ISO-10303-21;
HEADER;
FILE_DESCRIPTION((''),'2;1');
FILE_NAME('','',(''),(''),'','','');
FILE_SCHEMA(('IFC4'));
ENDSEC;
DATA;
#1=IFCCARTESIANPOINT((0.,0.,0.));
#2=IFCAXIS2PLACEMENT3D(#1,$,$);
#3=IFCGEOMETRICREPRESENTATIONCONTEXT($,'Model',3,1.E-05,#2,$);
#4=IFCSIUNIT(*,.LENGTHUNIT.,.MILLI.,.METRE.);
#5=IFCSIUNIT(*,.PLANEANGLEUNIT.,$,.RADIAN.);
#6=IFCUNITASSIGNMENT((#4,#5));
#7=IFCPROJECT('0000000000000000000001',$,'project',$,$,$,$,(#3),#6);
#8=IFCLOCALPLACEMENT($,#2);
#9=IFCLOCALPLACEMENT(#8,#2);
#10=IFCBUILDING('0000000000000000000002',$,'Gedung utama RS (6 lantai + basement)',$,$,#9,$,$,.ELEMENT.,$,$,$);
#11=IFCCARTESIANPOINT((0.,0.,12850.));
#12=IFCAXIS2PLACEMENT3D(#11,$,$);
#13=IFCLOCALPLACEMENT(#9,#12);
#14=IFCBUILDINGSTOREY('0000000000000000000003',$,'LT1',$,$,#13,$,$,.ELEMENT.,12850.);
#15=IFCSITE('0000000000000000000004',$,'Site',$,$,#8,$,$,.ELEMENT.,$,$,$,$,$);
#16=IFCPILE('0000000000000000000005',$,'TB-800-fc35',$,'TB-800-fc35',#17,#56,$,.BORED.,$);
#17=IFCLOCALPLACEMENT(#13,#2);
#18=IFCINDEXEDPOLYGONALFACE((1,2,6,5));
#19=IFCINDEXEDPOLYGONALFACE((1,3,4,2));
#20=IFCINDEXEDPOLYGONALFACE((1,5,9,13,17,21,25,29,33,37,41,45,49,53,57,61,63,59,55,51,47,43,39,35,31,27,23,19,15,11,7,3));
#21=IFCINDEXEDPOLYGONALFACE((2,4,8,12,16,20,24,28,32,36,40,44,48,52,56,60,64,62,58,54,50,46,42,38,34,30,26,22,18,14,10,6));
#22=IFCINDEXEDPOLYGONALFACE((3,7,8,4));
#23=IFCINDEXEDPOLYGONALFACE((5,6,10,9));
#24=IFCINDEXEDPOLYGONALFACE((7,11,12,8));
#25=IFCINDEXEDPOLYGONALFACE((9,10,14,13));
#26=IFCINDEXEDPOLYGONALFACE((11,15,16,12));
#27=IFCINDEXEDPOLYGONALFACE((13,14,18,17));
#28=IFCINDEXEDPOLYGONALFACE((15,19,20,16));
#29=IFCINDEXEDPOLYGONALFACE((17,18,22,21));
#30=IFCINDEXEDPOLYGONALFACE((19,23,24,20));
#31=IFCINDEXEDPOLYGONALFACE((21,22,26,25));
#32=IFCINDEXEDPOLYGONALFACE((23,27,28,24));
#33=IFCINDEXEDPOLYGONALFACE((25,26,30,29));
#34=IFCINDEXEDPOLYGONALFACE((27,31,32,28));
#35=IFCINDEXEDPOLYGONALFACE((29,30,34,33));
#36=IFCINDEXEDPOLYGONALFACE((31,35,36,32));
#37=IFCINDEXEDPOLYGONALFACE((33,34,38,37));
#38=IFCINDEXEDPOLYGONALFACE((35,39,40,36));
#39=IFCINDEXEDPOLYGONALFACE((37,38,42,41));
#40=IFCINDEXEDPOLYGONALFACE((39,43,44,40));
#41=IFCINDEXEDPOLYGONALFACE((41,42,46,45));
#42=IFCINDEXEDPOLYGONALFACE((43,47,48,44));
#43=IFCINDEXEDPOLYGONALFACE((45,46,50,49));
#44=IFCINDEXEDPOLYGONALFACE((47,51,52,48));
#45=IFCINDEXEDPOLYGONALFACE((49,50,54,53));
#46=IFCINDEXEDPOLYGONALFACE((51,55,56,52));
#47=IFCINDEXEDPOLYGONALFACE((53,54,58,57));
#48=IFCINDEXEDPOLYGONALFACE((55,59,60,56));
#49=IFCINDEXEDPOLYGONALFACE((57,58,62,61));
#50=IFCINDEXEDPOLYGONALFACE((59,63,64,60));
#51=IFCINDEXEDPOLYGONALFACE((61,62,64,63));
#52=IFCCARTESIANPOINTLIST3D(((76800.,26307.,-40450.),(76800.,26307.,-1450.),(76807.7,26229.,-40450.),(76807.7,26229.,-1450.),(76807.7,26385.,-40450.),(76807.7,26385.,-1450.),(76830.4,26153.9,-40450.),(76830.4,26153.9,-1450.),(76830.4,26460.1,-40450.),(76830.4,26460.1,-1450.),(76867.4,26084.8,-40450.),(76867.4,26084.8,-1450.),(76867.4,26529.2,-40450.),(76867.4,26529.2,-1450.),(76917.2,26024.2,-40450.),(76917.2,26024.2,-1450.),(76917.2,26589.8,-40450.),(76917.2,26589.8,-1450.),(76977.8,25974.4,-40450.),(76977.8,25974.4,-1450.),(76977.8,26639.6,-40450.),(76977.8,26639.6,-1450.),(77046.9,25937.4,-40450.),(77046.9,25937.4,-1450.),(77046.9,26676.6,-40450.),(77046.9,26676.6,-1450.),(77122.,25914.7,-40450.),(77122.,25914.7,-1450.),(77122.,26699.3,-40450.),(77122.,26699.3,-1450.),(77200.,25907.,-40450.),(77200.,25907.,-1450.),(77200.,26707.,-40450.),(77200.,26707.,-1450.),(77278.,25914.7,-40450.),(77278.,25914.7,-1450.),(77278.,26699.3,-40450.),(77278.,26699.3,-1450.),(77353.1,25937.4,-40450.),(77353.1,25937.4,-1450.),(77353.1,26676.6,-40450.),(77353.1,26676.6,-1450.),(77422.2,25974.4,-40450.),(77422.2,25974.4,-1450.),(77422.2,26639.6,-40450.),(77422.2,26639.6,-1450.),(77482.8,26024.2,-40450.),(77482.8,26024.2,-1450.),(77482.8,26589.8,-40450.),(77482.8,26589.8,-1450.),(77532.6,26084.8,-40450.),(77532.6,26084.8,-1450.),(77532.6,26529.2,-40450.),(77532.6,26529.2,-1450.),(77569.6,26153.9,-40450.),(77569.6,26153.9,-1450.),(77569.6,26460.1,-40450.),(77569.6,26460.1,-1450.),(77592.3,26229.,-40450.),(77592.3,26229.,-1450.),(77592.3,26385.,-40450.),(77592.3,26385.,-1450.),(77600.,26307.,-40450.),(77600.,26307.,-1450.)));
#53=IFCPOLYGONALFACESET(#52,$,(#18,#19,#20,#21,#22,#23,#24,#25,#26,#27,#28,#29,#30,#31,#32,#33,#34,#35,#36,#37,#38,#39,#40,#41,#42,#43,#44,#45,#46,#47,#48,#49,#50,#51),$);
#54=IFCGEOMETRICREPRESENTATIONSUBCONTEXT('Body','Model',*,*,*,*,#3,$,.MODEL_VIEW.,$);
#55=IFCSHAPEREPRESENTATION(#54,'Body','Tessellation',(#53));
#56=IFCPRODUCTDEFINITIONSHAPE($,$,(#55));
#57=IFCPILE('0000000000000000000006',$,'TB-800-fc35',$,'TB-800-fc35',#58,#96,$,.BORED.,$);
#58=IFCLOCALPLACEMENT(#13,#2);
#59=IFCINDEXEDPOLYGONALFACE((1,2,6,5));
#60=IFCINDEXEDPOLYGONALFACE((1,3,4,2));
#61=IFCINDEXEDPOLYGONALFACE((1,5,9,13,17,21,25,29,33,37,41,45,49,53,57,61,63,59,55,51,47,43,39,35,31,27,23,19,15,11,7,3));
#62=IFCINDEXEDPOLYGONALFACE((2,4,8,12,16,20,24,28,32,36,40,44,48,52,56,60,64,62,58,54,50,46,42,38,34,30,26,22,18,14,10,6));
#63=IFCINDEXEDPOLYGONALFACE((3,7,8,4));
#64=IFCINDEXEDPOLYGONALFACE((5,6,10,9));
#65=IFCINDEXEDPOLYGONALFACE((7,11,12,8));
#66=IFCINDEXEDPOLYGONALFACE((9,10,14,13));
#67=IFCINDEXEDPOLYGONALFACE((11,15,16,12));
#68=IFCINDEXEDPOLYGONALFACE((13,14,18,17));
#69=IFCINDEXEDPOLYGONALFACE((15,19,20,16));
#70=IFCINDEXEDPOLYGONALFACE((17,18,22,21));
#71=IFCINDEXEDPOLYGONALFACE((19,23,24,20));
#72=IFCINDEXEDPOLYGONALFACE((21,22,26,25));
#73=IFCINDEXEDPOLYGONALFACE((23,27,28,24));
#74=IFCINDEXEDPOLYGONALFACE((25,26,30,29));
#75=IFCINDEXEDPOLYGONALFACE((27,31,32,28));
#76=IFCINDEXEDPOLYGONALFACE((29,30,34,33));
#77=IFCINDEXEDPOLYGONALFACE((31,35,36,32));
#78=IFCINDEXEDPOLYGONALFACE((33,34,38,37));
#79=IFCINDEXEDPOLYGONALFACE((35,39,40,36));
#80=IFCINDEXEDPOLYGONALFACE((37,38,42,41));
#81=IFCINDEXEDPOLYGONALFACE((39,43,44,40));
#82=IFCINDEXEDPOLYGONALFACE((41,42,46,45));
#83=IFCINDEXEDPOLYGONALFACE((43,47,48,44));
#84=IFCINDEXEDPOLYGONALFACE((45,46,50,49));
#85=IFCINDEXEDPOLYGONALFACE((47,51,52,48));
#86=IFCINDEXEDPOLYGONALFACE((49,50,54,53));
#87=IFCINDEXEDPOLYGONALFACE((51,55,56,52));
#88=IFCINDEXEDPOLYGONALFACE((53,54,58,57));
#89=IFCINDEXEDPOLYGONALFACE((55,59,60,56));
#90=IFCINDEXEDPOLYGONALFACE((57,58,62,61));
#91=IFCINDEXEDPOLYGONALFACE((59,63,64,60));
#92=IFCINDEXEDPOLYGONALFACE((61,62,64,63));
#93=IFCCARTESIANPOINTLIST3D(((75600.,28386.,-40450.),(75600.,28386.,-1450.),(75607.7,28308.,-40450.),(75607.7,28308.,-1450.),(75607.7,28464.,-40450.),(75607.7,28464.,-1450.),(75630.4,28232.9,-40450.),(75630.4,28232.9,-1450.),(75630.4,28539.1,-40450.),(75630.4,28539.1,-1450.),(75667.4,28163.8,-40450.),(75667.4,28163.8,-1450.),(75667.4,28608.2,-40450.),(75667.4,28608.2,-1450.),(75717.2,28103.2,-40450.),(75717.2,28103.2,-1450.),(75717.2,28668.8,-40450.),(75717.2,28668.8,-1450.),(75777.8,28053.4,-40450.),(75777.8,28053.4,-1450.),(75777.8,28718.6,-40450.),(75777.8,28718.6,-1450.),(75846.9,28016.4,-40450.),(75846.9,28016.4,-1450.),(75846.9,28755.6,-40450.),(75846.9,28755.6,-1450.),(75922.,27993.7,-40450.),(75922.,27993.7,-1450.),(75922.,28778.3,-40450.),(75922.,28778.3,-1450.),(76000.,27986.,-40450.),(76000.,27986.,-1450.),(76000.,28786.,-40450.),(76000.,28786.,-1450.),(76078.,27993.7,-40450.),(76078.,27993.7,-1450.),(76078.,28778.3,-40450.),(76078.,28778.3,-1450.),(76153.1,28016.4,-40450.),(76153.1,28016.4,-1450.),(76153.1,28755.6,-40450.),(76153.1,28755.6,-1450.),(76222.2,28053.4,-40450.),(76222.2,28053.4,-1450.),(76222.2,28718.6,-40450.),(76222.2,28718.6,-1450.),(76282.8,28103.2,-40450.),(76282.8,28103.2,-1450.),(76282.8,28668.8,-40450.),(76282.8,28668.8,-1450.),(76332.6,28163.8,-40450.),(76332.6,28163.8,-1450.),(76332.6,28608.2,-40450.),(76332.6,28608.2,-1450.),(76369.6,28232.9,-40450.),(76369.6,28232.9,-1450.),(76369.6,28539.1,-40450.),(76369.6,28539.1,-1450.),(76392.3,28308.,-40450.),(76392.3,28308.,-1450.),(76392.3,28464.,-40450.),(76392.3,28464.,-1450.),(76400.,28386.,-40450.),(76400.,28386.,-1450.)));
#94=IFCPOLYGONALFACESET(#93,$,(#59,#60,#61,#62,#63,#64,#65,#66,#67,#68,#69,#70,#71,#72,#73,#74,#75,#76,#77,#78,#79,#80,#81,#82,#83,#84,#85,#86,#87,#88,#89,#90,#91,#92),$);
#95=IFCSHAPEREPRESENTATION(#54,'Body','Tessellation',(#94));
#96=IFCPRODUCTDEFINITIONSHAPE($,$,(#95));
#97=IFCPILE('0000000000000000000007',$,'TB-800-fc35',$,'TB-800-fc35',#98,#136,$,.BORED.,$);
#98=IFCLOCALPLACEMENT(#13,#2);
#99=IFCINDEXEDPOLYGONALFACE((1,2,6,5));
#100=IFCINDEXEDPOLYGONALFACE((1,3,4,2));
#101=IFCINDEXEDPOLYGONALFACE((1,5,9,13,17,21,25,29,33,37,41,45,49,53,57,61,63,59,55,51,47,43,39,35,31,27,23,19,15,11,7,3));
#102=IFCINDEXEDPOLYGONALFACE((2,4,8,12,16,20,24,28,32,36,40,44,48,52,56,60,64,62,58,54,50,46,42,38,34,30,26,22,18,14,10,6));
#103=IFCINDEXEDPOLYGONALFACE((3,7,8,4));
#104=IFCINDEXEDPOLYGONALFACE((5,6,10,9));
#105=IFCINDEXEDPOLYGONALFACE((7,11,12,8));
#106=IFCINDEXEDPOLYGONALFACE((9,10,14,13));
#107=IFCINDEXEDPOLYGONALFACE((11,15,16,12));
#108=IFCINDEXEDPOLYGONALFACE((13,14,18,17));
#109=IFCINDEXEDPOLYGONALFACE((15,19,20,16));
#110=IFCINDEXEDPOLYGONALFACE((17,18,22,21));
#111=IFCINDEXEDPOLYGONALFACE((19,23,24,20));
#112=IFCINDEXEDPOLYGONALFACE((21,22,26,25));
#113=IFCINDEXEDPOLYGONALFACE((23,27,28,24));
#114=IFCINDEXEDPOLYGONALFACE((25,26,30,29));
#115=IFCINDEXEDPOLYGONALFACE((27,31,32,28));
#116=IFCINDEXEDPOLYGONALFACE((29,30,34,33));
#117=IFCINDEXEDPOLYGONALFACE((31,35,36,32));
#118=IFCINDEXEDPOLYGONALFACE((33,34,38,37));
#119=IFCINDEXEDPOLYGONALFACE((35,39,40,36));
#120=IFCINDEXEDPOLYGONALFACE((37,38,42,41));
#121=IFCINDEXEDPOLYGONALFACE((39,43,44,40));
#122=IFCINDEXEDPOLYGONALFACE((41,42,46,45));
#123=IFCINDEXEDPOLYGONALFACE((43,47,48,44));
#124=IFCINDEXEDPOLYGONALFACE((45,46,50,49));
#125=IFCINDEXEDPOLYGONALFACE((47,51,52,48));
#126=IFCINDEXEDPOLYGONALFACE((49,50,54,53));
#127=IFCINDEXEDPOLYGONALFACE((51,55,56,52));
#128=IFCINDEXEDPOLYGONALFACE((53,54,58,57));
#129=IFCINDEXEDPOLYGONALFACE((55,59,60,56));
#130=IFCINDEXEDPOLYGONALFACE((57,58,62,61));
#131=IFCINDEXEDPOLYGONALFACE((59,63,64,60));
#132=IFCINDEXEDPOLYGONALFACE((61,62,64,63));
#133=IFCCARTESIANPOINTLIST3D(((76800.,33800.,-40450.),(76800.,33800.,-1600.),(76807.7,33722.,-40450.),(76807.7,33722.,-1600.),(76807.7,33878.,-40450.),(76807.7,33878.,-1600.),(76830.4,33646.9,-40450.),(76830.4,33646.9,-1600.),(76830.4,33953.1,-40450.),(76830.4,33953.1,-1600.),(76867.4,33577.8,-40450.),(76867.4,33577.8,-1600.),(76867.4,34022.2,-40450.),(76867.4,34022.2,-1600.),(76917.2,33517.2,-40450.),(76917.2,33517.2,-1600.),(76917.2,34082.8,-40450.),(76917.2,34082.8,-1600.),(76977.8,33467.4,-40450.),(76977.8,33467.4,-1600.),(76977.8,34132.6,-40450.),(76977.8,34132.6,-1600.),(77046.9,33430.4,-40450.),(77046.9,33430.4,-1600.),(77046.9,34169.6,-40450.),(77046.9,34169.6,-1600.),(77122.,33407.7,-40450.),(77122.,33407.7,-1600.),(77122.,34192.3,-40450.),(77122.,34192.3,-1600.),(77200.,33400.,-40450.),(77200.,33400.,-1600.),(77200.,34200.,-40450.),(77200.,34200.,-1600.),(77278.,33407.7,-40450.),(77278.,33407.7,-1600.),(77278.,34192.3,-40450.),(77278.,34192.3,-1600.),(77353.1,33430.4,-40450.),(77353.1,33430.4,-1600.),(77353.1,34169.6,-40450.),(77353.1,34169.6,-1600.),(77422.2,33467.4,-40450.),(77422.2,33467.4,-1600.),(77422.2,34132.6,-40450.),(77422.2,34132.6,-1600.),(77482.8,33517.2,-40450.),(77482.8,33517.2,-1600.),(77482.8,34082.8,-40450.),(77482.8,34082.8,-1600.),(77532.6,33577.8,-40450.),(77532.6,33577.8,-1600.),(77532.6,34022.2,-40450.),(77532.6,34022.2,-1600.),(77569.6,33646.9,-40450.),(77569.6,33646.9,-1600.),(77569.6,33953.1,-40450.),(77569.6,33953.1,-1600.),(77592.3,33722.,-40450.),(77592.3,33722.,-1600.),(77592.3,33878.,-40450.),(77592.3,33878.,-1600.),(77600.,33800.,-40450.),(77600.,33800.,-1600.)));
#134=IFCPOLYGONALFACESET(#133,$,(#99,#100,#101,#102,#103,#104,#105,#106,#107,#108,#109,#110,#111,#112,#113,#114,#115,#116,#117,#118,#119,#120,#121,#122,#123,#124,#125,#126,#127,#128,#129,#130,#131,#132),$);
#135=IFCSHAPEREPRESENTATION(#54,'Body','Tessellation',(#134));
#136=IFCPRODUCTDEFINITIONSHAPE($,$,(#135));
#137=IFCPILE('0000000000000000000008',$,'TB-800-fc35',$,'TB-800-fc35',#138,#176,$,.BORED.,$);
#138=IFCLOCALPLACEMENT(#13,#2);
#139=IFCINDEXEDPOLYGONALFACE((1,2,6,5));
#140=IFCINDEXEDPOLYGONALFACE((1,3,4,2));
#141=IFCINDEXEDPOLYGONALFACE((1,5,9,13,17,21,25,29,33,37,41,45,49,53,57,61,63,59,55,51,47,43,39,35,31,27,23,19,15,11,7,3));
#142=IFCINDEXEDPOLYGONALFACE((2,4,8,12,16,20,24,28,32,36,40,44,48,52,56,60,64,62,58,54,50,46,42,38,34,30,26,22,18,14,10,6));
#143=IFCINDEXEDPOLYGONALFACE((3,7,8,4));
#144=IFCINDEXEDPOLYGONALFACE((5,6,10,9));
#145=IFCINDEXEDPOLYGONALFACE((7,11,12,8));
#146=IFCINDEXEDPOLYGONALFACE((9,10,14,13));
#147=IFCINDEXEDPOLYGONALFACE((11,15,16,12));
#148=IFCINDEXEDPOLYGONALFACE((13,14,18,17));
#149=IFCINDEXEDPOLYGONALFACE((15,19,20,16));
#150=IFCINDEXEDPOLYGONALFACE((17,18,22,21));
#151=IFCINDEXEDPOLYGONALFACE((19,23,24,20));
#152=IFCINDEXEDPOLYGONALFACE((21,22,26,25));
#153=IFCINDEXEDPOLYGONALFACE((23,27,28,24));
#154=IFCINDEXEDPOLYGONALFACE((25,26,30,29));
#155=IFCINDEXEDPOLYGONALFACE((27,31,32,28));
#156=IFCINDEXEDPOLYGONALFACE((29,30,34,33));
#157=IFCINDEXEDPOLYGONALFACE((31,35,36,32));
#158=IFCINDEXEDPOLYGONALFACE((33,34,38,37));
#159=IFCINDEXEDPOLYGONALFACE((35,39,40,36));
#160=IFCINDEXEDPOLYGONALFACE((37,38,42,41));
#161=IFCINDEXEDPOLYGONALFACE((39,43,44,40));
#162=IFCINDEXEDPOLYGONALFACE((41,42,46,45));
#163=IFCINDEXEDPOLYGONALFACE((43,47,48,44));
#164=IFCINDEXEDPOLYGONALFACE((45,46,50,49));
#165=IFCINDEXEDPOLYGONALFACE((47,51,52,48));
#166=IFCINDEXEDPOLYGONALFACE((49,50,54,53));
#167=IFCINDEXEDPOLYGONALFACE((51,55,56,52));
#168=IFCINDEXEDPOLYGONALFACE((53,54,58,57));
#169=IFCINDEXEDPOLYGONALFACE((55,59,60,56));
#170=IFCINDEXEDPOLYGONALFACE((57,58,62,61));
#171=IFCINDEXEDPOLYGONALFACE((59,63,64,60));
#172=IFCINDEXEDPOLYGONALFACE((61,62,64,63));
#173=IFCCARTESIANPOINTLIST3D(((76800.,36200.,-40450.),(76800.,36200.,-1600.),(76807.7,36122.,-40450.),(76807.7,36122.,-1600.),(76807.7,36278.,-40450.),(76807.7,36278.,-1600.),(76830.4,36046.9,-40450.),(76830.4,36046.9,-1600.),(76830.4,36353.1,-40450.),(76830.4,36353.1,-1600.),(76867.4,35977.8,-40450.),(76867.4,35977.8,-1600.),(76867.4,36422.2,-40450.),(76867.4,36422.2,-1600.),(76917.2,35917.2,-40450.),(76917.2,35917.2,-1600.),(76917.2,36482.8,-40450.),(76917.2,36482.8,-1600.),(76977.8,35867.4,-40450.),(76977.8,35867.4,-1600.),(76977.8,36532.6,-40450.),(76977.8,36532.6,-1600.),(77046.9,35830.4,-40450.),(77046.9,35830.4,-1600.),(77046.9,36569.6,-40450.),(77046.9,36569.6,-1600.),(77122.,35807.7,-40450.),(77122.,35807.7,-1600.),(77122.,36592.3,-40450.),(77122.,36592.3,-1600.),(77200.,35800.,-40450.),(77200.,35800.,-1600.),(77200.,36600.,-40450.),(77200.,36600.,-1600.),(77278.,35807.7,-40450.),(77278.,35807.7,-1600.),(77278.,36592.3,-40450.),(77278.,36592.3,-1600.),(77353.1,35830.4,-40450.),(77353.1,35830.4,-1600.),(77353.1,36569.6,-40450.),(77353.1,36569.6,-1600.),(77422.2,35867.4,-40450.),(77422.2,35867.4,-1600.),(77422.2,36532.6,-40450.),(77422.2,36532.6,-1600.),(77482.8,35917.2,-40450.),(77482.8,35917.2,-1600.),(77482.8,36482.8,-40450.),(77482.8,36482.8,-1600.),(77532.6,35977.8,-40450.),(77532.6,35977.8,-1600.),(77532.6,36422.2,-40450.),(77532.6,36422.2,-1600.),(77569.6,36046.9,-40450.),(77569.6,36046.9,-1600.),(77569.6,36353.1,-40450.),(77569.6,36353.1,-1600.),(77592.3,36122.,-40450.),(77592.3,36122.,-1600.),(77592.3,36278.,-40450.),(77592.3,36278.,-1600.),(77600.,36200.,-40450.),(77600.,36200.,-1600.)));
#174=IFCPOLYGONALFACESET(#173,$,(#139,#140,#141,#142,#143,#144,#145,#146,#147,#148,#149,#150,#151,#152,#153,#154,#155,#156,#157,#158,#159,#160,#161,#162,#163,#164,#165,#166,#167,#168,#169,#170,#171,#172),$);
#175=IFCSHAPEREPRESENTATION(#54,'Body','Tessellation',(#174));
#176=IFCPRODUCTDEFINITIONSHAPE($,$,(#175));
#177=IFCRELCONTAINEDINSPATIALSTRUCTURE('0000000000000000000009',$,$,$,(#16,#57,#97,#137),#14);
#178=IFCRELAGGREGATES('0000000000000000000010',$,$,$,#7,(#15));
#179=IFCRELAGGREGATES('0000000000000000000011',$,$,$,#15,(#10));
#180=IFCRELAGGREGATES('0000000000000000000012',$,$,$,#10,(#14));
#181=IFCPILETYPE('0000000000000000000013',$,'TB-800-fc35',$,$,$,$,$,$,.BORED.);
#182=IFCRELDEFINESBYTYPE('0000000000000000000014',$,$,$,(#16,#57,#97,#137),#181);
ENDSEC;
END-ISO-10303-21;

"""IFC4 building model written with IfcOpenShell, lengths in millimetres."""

from ifc_helpers import new_model, si_unit, frame, origin, origin_2d, place, context, subcontext, project, spatial, circle, extrude, material_profile, profile_set, profile_usage, type_object, element, save


model = new_model("IFC4")

# Units and contexts
model_context = context("Model", 3, precision=1e-05, world=origin())
body_context = subcontext(model_context, "Body", "Model", "MODEL_VIEW")
ifc_project = project(units=[si_unit("LENGTHUNIT", "METRE", prefix="MILLI"), si_unit("PLANEANGLEUNIT", "RADIAN")], contexts=[model_context])

# Site, building, storey
site_placement = place(None, origin())
site = spatial("IfcSite", under=ifc_project, at=site_placement, Name="Site", CompositionType="ELEMENT")
building_placement = place(site_placement, origin())
building = spatial("IfcBuilding", under=site, at=building_placement, Name="Gedung utama RS (6 lantai + basement)", CompositionType="ELEMENT")
storey_placement = place(building_placement, frame((0.0, 0.0, 12850.0)))
storey = spatial("IfcBuildingStorey", under=building, at=storey_placement, Name="LT1", CompositionType="ELEMENT", Elevation=12850.0)

# Piles
ifc_material_profile_1 = material_profile(None, circle(Radius=400.0, at=origin_2d()), Name="TB-800-fc35")
ifc_profile_set_1 = profile_set([ifc_material_profile_1], Name="TB-800-fc35")
ifc_profile_usage_1 = profile_usage(ifc_profile_set_1, cardinal=5)
pile_type = type_object("IfcPileType", Name="TB-800-fc35", PredefinedType="BORED", material=ifc_profile_set_1)
for number, where, z_axis, x_axis, name in (
    (1, (77200.0, 26307.0, -40450.0), (0.0, 0.0, 1.0), (1.0, 0.0, 0.0), "TB-800-fc35"),
    (2, (76000.0, 28386.0, -40450.0), (0.0, 0.0, 1.0), (1.0, 0.0, 0.0), "TB-800-fc35"),
):
    element("IfcPile", number, at=place(storey_placement, frame(where, z_axis=z_axis, x_axis=x_axis)), inside=storey, type_object=pile_type, material=ifc_profile_usage_1, Name=name, ObjectType="TB-800-fc35", PredefinedType="BORED", context=body_context, shape_type="SweptSolid", body=[
        extrude(circle(Radius=400.0, at=origin_2d()), origin(), (0.0, 0.0, 1.0), 39000.0),
    ])
for number, where, z_axis, x_axis, name in (
    (3, (77200.0, 33800.0, -40450.0), (0.0, 0.0, 1.0), (1.0, 0.0, 0.0), "TB-800-fc35"),
    (4, (77200.0, 36200.0, -40450.0), (0.0, 0.0, 1.0), (1.0, 0.0, 0.0), "TB-800-fc35"),
):
    element("IfcPile", number, at=place(storey_placement, frame(where, z_axis=z_axis, x_axis=x_axis)), inside=storey, type_object=pile_type, material=ifc_profile_usage_1, Name=name, ObjectType="TB-800-fc35", PredefinedType="BORED", context=body_context, shape_type="SweptSolid", body=[
        extrude(circle(Radius=400.0, at=origin_2d()), origin(), (0.0, 0.0, 1.0), 38850.0),
    ])

save(model, "model.ifc")
